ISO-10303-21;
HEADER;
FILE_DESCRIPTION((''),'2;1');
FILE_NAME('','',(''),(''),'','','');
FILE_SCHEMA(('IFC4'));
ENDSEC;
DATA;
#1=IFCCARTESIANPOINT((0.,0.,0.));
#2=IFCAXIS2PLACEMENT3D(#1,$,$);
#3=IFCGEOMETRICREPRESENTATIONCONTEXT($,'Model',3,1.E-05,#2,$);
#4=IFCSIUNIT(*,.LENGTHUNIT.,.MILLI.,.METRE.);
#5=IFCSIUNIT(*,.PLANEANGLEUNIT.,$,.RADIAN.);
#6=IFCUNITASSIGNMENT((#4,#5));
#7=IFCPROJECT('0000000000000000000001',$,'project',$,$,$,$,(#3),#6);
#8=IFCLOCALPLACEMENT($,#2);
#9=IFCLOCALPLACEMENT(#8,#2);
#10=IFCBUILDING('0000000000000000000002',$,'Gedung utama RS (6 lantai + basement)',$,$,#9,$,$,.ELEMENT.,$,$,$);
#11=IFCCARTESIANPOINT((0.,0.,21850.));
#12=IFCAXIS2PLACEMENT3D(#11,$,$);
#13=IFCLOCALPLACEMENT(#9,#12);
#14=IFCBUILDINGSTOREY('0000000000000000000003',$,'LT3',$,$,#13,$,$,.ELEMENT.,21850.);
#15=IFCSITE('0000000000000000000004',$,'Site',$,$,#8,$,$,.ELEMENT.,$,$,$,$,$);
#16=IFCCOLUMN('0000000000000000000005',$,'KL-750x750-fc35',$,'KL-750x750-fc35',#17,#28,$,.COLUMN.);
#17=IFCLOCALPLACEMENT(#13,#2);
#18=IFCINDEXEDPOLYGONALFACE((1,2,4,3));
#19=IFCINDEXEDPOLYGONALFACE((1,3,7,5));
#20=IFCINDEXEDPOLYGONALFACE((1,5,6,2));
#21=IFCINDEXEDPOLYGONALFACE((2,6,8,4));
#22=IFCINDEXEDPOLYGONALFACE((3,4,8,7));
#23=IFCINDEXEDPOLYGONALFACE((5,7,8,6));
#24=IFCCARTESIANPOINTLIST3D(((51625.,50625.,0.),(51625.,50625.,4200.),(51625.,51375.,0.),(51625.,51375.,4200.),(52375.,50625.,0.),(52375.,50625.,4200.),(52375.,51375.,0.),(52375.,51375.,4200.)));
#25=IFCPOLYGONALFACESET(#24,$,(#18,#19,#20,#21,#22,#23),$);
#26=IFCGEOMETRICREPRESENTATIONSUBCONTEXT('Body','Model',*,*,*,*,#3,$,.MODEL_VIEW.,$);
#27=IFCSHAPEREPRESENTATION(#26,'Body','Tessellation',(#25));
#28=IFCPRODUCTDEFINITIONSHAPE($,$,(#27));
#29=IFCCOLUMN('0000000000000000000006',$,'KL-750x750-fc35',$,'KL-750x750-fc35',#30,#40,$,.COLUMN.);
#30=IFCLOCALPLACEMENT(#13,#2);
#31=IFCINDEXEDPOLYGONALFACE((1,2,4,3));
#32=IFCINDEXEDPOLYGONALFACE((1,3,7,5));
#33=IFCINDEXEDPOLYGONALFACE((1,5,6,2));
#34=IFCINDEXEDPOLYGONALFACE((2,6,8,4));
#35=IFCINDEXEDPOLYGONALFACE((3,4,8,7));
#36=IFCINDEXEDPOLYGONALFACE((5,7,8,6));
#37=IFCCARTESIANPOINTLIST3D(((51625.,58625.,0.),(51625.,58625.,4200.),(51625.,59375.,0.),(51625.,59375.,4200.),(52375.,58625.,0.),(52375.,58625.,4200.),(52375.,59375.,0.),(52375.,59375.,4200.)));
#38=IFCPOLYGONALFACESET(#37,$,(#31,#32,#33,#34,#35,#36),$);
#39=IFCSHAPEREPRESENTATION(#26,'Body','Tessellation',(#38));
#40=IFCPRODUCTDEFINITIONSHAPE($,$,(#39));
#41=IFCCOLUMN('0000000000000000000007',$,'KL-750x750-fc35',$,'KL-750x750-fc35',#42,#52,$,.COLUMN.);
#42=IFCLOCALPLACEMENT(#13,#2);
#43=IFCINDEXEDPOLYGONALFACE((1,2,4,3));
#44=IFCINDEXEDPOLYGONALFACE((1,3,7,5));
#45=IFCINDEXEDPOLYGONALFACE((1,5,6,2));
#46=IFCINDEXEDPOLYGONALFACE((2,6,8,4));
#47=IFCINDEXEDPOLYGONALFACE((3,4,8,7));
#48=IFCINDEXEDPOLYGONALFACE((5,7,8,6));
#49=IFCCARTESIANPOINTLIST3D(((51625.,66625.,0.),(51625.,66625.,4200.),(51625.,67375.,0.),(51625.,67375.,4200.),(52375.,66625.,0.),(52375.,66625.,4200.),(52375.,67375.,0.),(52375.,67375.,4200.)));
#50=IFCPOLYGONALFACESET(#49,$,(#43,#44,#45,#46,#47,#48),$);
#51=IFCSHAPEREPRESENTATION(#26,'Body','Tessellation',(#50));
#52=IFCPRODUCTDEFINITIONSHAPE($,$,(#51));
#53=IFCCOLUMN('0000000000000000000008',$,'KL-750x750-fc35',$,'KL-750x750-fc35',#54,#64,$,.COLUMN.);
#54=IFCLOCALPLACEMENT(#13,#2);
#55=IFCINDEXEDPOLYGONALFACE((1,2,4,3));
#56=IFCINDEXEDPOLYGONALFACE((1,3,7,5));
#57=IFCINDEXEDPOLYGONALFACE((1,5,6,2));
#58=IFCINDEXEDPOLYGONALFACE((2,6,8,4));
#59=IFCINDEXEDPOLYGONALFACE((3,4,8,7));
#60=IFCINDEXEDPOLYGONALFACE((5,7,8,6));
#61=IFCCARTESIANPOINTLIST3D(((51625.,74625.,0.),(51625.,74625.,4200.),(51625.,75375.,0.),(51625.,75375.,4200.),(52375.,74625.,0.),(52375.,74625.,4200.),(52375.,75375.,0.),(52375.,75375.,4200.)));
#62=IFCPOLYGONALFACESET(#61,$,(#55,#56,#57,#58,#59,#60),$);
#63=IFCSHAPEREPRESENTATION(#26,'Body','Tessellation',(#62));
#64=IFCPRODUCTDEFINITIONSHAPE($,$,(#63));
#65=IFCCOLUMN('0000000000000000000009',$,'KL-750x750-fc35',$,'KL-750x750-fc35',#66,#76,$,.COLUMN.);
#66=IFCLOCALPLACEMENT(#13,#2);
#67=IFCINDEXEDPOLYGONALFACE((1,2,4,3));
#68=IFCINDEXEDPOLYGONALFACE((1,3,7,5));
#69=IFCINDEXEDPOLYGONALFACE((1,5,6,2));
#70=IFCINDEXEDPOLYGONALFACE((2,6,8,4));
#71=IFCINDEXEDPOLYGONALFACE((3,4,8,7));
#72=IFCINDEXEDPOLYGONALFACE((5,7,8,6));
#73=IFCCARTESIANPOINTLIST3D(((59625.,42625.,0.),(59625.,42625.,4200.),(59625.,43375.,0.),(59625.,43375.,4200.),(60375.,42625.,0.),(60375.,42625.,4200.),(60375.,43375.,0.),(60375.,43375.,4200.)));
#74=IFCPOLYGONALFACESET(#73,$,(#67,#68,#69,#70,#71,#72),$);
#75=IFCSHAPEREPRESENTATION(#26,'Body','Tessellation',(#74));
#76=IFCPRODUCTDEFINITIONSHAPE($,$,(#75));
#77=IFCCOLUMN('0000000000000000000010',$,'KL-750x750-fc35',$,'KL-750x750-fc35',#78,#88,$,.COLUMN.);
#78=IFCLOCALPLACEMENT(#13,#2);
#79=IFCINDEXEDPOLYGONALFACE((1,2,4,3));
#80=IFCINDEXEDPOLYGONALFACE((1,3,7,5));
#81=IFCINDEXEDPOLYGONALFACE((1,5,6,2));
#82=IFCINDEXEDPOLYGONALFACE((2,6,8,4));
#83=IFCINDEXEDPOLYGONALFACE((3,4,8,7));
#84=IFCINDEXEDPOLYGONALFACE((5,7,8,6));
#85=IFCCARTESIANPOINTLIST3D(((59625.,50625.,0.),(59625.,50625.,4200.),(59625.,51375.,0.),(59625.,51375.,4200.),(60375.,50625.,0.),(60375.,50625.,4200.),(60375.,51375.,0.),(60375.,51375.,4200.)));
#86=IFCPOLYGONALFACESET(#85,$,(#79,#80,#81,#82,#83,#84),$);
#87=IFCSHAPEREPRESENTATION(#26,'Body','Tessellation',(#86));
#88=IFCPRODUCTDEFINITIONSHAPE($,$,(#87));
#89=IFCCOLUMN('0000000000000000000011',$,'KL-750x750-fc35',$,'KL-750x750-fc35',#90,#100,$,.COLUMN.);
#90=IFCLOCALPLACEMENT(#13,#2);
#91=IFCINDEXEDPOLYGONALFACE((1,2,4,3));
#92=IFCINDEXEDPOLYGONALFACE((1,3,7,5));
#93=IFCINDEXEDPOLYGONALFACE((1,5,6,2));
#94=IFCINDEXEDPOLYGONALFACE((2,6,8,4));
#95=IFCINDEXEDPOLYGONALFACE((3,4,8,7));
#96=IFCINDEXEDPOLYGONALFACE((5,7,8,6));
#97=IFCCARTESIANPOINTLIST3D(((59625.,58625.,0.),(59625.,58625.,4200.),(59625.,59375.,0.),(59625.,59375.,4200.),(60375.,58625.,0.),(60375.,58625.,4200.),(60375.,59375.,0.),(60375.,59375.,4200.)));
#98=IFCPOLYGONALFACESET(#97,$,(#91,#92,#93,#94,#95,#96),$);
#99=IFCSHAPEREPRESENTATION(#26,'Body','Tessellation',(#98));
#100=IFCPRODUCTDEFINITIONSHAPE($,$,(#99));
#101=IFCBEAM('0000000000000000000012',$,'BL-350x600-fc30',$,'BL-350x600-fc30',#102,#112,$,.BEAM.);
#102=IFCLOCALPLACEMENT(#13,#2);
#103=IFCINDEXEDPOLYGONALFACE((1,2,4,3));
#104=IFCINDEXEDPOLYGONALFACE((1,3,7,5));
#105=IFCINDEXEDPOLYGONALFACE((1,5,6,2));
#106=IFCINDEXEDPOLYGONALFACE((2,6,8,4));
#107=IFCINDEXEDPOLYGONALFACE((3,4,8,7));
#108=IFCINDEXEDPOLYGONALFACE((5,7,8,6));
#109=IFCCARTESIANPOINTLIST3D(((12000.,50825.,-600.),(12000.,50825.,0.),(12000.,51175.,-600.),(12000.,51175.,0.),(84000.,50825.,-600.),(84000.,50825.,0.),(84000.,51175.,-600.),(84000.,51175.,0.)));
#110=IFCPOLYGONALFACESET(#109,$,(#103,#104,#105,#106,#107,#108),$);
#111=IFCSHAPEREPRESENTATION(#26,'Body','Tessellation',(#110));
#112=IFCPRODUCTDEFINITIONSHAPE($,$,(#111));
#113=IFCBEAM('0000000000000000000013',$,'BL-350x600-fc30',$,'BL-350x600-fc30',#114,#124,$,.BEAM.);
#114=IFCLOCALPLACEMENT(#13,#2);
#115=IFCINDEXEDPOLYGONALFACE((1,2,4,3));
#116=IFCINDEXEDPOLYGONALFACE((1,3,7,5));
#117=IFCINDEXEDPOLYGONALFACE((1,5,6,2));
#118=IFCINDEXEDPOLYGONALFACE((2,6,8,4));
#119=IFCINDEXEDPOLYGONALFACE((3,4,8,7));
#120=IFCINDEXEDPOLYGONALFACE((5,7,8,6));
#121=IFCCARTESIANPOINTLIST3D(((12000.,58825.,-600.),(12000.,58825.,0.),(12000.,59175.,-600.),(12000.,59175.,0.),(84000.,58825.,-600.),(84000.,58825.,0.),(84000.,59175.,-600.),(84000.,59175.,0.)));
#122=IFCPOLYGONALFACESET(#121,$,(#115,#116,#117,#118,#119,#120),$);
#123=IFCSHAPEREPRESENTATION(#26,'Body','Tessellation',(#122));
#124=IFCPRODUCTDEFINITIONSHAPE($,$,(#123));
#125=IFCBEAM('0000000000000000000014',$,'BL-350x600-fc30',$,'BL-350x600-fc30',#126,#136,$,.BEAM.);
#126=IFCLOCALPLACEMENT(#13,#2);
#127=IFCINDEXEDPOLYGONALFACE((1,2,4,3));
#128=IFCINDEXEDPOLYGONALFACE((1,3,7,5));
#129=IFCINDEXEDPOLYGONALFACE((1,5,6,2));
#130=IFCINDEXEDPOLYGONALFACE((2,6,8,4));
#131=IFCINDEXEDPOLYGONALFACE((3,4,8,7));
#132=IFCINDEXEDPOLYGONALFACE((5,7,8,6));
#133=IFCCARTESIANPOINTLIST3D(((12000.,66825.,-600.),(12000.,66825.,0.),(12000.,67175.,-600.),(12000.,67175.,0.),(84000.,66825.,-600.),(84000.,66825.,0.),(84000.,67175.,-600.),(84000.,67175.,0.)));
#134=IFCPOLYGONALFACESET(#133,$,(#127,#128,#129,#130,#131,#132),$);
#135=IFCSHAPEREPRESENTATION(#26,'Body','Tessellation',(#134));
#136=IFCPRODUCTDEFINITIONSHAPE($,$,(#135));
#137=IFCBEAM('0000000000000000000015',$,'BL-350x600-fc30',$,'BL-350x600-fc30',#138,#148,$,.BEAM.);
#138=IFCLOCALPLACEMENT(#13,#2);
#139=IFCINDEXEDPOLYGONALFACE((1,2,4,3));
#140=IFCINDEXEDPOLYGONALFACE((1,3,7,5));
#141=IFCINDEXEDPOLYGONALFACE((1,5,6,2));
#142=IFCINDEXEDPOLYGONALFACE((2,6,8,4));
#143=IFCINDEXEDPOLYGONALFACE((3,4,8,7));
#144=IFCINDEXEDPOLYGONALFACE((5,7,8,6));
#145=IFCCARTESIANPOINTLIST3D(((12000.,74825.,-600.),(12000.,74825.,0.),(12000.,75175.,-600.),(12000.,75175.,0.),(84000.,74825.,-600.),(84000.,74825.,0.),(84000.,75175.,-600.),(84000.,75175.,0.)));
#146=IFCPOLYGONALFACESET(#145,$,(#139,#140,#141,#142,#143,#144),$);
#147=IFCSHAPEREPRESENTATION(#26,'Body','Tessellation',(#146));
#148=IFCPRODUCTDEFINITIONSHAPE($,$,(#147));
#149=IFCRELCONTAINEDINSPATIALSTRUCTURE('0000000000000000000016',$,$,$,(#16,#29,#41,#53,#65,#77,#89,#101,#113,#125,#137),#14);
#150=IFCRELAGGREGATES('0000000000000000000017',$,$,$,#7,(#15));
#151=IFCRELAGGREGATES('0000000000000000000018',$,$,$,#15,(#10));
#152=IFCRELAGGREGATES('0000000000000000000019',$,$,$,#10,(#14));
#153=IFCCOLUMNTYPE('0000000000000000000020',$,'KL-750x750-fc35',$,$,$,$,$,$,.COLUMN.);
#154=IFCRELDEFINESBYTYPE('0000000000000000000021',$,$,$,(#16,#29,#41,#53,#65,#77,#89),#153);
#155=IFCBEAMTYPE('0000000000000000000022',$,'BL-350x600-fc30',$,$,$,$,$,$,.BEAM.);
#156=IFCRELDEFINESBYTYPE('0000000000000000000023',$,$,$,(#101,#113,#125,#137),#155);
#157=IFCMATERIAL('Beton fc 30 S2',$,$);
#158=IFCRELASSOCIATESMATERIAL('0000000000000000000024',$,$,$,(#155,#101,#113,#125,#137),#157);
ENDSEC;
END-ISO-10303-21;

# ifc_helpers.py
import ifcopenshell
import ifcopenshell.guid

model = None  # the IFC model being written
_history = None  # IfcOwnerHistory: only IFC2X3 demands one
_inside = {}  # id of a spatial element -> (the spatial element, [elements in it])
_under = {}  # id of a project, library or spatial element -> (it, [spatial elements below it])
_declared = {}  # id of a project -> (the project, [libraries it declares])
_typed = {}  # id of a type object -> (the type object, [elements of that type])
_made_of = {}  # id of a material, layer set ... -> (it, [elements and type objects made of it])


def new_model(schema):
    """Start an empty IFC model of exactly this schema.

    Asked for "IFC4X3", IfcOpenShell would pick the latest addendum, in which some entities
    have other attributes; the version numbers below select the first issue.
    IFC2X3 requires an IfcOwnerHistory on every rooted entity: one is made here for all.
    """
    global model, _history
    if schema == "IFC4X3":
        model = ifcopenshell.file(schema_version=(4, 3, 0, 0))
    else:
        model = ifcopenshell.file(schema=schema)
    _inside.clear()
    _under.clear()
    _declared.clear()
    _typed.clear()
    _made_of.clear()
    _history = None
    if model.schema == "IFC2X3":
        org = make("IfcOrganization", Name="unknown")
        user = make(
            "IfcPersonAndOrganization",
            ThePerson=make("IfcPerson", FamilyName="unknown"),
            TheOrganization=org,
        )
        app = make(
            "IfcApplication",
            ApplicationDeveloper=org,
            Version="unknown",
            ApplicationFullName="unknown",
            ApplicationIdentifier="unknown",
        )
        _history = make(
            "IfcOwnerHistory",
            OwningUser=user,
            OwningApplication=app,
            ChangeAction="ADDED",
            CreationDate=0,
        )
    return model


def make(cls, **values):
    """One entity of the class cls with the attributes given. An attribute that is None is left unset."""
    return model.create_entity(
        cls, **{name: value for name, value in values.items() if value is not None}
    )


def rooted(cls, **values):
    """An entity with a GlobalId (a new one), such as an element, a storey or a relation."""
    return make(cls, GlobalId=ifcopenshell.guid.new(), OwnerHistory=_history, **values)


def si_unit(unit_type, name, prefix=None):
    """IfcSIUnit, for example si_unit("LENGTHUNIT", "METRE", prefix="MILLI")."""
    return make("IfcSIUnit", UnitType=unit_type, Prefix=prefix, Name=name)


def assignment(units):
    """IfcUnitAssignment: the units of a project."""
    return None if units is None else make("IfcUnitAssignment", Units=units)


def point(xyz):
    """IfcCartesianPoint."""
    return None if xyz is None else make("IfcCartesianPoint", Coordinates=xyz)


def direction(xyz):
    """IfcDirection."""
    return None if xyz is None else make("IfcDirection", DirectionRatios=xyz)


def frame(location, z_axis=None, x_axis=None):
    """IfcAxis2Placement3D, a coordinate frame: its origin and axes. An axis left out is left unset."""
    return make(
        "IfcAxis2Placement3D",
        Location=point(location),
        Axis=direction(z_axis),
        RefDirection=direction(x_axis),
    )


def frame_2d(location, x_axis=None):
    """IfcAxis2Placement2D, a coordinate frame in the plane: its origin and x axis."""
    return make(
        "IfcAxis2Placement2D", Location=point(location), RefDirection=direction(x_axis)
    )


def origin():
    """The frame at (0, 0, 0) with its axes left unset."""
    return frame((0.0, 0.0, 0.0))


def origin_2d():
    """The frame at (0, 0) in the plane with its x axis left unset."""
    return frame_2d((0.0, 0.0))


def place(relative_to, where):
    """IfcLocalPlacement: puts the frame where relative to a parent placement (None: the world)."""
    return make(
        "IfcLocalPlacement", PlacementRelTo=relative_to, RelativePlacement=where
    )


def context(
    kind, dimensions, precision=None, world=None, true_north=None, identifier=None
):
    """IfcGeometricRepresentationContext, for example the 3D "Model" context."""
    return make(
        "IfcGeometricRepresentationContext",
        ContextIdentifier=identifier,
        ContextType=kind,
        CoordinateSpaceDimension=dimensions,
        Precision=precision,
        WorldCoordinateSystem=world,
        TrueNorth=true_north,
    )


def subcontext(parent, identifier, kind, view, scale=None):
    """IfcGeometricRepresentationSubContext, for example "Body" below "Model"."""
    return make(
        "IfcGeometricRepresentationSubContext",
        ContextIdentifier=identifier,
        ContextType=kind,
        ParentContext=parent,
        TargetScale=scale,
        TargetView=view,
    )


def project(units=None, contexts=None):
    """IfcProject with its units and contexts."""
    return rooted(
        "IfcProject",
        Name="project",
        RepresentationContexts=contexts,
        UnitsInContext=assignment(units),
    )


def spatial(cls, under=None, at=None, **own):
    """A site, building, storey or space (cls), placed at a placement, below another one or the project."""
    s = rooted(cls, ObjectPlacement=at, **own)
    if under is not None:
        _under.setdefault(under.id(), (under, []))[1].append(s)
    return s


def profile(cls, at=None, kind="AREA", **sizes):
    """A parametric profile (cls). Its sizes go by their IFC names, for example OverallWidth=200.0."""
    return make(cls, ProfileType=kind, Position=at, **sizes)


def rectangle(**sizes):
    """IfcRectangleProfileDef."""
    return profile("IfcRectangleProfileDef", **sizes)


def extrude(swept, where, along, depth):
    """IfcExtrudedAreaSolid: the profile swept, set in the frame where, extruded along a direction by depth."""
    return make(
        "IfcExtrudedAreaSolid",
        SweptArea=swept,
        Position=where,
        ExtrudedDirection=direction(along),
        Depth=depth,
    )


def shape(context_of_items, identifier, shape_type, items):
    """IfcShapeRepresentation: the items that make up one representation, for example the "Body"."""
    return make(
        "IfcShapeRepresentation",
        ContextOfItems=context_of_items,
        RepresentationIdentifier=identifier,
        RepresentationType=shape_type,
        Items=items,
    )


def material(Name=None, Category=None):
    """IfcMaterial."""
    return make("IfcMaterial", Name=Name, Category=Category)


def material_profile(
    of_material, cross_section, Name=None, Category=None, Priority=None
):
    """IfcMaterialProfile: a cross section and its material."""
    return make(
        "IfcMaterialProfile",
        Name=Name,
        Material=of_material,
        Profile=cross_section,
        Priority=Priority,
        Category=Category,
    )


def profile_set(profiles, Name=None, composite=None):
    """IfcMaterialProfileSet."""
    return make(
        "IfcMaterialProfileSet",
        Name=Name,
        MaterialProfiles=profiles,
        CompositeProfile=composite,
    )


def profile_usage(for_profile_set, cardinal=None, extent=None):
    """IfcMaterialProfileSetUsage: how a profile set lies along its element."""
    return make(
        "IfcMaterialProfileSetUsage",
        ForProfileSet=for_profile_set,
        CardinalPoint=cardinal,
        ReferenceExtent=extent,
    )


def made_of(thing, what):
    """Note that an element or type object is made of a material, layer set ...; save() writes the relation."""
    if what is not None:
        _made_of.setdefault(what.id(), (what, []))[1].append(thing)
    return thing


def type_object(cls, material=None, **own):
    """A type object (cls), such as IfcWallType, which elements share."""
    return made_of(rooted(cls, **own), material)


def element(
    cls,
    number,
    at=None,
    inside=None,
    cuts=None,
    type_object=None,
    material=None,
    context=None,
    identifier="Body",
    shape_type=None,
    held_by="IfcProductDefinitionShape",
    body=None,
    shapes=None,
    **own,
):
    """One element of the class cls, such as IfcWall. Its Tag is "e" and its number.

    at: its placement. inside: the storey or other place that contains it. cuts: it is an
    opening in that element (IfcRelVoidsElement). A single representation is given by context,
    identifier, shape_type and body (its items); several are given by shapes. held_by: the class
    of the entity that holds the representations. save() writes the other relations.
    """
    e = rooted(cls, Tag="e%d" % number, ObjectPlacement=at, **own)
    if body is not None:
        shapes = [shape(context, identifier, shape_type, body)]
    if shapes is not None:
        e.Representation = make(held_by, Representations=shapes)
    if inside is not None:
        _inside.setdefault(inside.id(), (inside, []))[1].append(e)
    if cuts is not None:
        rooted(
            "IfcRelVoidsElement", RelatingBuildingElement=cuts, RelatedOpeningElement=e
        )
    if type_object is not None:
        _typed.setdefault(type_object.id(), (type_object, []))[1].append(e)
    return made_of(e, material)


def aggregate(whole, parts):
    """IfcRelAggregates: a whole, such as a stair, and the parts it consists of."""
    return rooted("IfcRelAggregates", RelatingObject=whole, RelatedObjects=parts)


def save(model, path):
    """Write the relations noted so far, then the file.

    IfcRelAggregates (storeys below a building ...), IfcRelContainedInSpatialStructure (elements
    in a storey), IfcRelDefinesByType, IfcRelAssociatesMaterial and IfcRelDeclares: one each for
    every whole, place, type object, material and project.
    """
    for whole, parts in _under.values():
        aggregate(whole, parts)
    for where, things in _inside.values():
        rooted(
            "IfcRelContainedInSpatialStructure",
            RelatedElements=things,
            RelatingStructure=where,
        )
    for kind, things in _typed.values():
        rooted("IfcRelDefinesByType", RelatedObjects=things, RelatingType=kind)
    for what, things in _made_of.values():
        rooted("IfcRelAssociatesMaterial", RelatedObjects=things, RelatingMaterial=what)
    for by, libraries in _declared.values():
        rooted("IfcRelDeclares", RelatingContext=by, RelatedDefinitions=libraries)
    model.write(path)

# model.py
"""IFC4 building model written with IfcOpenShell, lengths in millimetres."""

from ifc_helpers import new_model, si_unit, frame, origin, origin_2d, place, context, subcontext, project, spatial, rectangle, extrude, material, material_profile, profile_set, profile_usage, type_object, element, save


model = new_model("IFC4")

# Units and contexts
model_context = context("Model", 3, precision=1e-05, world=origin())
body_context = subcontext(model_context, "Body", "Model", "MODEL_VIEW")
ifc_project = project(units=[si_unit("LENGTHUNIT", "METRE", prefix="MILLI"), si_unit("PLANEANGLEUNIT", "RADIAN")], contexts=[model_context])

# Site, building, storey
site_placement = place(None, origin())
site = spatial("IfcSite", under=ifc_project, at=site_placement, Name="Site", CompositionType="ELEMENT")
building_placement = place(site_placement, origin())
building = spatial("IfcBuilding", under=site, at=building_placement, Name="Gedung utama RS (6 lantai + basement)", CompositionType="ELEMENT")
storey_placement = place(building_placement, frame((0.0, 0.0, 21850.0)))
storey = spatial("IfcBuildingStorey", under=building, at=storey_placement, Name="LT3", CompositionType="ELEMENT", Elevation=21850.0)

# Columns
ifc_material_profile_1 = material_profile(None, rectangle(XDim=750.0, YDim=750.0, at=origin_2d()), Name="KL-750x750-fc35")
ifc_profile_set_1 = profile_set([ifc_material_profile_1], Name="KL-750x750-fc35")
ifc_profile_usage_1 = profile_usage(ifc_profile_set_1, cardinal=5)
column_type = type_object("IfcColumnType", Name="KL-750x750-fc35", PredefinedType="COLUMN", material=ifc_profile_set_1)
for number, where, z_axis, x_axis, name in (
    (1, (52000.0, 51000.0, 0.0), (0.0, 0.0, 1.0), (1.0, 0.0, 0.0), "KL-750x750-fc35"),
    (2, (52000.0, 59000.0, 0.0), (0.0, 0.0, 1.0), (1.0, 0.0, 0.0), "KL-750x750-fc35"),
    (3, (52000.0, 67000.0, 0.0), (0.0, 0.0, 1.0), (1.0, 0.0, 0.0), "KL-750x750-fc35"),
    (4, (52000.0, 75000.0, 0.0), (0.0, 0.0, 1.0), (1.0, 0.0, 0.0), "KL-750x750-fc35"),
    (5, (60000.0, 43000.0, 0.0), (0.0, 0.0, 1.0), (1.0, 0.0, 0.0), "KL-750x750-fc35"),
    (6, (60000.0, 51000.0, 0.0), (0.0, 0.0, 1.0), (1.0, 0.0, 0.0), "KL-750x750-fc35"),
    (7, (60000.0, 59000.0, 0.0), (0.0, 0.0, 1.0), (1.0, 0.0, 0.0), "KL-750x750-fc35"),
):
    element("IfcColumn", number, at=place(storey_placement, frame(where, z_axis=z_axis, x_axis=x_axis)), inside=storey, type_object=column_type, material=ifc_profile_usage_1, Name=name, ObjectType="KL-750x750-fc35", PredefinedType="COLUMN", context=body_context, shape_type="SweptSolid", body=[
        extrude(rectangle(XDim=750.0, YDim=750.0, at=origin_2d()), origin(), (0.0, 0.0, 1.0), 4200.0),
    ])

# Beams
ifc_material = material(Name="Beton fc 30 S2")
ifc_material_profile_2 = material_profile(ifc_material, rectangle(XDim=350.0, YDim=600.0, at=origin_2d()), Name="BL-350x600-fc30")
ifc_profile_set_2 = profile_set([ifc_material_profile_2], Name="BL-350x600-fc30")
ifc_profile_usage_2 = profile_usage(ifc_profile_set_2, cardinal=8)
beam_type = type_object("IfcBeamType", Name="BL-350x600-fc30", PredefinedType="BEAM", material=ifc_profile_set_2)
for number, where, name in (
    (8, (12000.0, 51000.0, -300.0), "BL-350x600-fc30"),
    (9, (12000.0, 59000.0, -300.0), "BL-350x600-fc30"),
    (10, (12000.0, 67000.0, -300.0), "BL-350x600-fc30"),
    (11, (12000.0, 75000.0, -300.0), "BL-350x600-fc30"),
):
    element("IfcBeam", number, at=place(storey_placement, frame(where)), inside=storey, type_object=beam_type, material=ifc_profile_usage_2, Name=name, ObjectType="BL-350x600-fc30", PredefinedType="BEAM", context=body_context, shape_type="SweptSolid", body=[
        extrude(rectangle(XDim=350.0, YDim=600.0, at=origin_2d()), frame((0.0, 0.0, 0.0), z_axis=(1.0, 0.0, 0.0), x_axis=(0.0, 1.0, 0.0)), (0.0, 0.0, 1.0), 72000.0),
    ])

save(model, "model.ifc")
